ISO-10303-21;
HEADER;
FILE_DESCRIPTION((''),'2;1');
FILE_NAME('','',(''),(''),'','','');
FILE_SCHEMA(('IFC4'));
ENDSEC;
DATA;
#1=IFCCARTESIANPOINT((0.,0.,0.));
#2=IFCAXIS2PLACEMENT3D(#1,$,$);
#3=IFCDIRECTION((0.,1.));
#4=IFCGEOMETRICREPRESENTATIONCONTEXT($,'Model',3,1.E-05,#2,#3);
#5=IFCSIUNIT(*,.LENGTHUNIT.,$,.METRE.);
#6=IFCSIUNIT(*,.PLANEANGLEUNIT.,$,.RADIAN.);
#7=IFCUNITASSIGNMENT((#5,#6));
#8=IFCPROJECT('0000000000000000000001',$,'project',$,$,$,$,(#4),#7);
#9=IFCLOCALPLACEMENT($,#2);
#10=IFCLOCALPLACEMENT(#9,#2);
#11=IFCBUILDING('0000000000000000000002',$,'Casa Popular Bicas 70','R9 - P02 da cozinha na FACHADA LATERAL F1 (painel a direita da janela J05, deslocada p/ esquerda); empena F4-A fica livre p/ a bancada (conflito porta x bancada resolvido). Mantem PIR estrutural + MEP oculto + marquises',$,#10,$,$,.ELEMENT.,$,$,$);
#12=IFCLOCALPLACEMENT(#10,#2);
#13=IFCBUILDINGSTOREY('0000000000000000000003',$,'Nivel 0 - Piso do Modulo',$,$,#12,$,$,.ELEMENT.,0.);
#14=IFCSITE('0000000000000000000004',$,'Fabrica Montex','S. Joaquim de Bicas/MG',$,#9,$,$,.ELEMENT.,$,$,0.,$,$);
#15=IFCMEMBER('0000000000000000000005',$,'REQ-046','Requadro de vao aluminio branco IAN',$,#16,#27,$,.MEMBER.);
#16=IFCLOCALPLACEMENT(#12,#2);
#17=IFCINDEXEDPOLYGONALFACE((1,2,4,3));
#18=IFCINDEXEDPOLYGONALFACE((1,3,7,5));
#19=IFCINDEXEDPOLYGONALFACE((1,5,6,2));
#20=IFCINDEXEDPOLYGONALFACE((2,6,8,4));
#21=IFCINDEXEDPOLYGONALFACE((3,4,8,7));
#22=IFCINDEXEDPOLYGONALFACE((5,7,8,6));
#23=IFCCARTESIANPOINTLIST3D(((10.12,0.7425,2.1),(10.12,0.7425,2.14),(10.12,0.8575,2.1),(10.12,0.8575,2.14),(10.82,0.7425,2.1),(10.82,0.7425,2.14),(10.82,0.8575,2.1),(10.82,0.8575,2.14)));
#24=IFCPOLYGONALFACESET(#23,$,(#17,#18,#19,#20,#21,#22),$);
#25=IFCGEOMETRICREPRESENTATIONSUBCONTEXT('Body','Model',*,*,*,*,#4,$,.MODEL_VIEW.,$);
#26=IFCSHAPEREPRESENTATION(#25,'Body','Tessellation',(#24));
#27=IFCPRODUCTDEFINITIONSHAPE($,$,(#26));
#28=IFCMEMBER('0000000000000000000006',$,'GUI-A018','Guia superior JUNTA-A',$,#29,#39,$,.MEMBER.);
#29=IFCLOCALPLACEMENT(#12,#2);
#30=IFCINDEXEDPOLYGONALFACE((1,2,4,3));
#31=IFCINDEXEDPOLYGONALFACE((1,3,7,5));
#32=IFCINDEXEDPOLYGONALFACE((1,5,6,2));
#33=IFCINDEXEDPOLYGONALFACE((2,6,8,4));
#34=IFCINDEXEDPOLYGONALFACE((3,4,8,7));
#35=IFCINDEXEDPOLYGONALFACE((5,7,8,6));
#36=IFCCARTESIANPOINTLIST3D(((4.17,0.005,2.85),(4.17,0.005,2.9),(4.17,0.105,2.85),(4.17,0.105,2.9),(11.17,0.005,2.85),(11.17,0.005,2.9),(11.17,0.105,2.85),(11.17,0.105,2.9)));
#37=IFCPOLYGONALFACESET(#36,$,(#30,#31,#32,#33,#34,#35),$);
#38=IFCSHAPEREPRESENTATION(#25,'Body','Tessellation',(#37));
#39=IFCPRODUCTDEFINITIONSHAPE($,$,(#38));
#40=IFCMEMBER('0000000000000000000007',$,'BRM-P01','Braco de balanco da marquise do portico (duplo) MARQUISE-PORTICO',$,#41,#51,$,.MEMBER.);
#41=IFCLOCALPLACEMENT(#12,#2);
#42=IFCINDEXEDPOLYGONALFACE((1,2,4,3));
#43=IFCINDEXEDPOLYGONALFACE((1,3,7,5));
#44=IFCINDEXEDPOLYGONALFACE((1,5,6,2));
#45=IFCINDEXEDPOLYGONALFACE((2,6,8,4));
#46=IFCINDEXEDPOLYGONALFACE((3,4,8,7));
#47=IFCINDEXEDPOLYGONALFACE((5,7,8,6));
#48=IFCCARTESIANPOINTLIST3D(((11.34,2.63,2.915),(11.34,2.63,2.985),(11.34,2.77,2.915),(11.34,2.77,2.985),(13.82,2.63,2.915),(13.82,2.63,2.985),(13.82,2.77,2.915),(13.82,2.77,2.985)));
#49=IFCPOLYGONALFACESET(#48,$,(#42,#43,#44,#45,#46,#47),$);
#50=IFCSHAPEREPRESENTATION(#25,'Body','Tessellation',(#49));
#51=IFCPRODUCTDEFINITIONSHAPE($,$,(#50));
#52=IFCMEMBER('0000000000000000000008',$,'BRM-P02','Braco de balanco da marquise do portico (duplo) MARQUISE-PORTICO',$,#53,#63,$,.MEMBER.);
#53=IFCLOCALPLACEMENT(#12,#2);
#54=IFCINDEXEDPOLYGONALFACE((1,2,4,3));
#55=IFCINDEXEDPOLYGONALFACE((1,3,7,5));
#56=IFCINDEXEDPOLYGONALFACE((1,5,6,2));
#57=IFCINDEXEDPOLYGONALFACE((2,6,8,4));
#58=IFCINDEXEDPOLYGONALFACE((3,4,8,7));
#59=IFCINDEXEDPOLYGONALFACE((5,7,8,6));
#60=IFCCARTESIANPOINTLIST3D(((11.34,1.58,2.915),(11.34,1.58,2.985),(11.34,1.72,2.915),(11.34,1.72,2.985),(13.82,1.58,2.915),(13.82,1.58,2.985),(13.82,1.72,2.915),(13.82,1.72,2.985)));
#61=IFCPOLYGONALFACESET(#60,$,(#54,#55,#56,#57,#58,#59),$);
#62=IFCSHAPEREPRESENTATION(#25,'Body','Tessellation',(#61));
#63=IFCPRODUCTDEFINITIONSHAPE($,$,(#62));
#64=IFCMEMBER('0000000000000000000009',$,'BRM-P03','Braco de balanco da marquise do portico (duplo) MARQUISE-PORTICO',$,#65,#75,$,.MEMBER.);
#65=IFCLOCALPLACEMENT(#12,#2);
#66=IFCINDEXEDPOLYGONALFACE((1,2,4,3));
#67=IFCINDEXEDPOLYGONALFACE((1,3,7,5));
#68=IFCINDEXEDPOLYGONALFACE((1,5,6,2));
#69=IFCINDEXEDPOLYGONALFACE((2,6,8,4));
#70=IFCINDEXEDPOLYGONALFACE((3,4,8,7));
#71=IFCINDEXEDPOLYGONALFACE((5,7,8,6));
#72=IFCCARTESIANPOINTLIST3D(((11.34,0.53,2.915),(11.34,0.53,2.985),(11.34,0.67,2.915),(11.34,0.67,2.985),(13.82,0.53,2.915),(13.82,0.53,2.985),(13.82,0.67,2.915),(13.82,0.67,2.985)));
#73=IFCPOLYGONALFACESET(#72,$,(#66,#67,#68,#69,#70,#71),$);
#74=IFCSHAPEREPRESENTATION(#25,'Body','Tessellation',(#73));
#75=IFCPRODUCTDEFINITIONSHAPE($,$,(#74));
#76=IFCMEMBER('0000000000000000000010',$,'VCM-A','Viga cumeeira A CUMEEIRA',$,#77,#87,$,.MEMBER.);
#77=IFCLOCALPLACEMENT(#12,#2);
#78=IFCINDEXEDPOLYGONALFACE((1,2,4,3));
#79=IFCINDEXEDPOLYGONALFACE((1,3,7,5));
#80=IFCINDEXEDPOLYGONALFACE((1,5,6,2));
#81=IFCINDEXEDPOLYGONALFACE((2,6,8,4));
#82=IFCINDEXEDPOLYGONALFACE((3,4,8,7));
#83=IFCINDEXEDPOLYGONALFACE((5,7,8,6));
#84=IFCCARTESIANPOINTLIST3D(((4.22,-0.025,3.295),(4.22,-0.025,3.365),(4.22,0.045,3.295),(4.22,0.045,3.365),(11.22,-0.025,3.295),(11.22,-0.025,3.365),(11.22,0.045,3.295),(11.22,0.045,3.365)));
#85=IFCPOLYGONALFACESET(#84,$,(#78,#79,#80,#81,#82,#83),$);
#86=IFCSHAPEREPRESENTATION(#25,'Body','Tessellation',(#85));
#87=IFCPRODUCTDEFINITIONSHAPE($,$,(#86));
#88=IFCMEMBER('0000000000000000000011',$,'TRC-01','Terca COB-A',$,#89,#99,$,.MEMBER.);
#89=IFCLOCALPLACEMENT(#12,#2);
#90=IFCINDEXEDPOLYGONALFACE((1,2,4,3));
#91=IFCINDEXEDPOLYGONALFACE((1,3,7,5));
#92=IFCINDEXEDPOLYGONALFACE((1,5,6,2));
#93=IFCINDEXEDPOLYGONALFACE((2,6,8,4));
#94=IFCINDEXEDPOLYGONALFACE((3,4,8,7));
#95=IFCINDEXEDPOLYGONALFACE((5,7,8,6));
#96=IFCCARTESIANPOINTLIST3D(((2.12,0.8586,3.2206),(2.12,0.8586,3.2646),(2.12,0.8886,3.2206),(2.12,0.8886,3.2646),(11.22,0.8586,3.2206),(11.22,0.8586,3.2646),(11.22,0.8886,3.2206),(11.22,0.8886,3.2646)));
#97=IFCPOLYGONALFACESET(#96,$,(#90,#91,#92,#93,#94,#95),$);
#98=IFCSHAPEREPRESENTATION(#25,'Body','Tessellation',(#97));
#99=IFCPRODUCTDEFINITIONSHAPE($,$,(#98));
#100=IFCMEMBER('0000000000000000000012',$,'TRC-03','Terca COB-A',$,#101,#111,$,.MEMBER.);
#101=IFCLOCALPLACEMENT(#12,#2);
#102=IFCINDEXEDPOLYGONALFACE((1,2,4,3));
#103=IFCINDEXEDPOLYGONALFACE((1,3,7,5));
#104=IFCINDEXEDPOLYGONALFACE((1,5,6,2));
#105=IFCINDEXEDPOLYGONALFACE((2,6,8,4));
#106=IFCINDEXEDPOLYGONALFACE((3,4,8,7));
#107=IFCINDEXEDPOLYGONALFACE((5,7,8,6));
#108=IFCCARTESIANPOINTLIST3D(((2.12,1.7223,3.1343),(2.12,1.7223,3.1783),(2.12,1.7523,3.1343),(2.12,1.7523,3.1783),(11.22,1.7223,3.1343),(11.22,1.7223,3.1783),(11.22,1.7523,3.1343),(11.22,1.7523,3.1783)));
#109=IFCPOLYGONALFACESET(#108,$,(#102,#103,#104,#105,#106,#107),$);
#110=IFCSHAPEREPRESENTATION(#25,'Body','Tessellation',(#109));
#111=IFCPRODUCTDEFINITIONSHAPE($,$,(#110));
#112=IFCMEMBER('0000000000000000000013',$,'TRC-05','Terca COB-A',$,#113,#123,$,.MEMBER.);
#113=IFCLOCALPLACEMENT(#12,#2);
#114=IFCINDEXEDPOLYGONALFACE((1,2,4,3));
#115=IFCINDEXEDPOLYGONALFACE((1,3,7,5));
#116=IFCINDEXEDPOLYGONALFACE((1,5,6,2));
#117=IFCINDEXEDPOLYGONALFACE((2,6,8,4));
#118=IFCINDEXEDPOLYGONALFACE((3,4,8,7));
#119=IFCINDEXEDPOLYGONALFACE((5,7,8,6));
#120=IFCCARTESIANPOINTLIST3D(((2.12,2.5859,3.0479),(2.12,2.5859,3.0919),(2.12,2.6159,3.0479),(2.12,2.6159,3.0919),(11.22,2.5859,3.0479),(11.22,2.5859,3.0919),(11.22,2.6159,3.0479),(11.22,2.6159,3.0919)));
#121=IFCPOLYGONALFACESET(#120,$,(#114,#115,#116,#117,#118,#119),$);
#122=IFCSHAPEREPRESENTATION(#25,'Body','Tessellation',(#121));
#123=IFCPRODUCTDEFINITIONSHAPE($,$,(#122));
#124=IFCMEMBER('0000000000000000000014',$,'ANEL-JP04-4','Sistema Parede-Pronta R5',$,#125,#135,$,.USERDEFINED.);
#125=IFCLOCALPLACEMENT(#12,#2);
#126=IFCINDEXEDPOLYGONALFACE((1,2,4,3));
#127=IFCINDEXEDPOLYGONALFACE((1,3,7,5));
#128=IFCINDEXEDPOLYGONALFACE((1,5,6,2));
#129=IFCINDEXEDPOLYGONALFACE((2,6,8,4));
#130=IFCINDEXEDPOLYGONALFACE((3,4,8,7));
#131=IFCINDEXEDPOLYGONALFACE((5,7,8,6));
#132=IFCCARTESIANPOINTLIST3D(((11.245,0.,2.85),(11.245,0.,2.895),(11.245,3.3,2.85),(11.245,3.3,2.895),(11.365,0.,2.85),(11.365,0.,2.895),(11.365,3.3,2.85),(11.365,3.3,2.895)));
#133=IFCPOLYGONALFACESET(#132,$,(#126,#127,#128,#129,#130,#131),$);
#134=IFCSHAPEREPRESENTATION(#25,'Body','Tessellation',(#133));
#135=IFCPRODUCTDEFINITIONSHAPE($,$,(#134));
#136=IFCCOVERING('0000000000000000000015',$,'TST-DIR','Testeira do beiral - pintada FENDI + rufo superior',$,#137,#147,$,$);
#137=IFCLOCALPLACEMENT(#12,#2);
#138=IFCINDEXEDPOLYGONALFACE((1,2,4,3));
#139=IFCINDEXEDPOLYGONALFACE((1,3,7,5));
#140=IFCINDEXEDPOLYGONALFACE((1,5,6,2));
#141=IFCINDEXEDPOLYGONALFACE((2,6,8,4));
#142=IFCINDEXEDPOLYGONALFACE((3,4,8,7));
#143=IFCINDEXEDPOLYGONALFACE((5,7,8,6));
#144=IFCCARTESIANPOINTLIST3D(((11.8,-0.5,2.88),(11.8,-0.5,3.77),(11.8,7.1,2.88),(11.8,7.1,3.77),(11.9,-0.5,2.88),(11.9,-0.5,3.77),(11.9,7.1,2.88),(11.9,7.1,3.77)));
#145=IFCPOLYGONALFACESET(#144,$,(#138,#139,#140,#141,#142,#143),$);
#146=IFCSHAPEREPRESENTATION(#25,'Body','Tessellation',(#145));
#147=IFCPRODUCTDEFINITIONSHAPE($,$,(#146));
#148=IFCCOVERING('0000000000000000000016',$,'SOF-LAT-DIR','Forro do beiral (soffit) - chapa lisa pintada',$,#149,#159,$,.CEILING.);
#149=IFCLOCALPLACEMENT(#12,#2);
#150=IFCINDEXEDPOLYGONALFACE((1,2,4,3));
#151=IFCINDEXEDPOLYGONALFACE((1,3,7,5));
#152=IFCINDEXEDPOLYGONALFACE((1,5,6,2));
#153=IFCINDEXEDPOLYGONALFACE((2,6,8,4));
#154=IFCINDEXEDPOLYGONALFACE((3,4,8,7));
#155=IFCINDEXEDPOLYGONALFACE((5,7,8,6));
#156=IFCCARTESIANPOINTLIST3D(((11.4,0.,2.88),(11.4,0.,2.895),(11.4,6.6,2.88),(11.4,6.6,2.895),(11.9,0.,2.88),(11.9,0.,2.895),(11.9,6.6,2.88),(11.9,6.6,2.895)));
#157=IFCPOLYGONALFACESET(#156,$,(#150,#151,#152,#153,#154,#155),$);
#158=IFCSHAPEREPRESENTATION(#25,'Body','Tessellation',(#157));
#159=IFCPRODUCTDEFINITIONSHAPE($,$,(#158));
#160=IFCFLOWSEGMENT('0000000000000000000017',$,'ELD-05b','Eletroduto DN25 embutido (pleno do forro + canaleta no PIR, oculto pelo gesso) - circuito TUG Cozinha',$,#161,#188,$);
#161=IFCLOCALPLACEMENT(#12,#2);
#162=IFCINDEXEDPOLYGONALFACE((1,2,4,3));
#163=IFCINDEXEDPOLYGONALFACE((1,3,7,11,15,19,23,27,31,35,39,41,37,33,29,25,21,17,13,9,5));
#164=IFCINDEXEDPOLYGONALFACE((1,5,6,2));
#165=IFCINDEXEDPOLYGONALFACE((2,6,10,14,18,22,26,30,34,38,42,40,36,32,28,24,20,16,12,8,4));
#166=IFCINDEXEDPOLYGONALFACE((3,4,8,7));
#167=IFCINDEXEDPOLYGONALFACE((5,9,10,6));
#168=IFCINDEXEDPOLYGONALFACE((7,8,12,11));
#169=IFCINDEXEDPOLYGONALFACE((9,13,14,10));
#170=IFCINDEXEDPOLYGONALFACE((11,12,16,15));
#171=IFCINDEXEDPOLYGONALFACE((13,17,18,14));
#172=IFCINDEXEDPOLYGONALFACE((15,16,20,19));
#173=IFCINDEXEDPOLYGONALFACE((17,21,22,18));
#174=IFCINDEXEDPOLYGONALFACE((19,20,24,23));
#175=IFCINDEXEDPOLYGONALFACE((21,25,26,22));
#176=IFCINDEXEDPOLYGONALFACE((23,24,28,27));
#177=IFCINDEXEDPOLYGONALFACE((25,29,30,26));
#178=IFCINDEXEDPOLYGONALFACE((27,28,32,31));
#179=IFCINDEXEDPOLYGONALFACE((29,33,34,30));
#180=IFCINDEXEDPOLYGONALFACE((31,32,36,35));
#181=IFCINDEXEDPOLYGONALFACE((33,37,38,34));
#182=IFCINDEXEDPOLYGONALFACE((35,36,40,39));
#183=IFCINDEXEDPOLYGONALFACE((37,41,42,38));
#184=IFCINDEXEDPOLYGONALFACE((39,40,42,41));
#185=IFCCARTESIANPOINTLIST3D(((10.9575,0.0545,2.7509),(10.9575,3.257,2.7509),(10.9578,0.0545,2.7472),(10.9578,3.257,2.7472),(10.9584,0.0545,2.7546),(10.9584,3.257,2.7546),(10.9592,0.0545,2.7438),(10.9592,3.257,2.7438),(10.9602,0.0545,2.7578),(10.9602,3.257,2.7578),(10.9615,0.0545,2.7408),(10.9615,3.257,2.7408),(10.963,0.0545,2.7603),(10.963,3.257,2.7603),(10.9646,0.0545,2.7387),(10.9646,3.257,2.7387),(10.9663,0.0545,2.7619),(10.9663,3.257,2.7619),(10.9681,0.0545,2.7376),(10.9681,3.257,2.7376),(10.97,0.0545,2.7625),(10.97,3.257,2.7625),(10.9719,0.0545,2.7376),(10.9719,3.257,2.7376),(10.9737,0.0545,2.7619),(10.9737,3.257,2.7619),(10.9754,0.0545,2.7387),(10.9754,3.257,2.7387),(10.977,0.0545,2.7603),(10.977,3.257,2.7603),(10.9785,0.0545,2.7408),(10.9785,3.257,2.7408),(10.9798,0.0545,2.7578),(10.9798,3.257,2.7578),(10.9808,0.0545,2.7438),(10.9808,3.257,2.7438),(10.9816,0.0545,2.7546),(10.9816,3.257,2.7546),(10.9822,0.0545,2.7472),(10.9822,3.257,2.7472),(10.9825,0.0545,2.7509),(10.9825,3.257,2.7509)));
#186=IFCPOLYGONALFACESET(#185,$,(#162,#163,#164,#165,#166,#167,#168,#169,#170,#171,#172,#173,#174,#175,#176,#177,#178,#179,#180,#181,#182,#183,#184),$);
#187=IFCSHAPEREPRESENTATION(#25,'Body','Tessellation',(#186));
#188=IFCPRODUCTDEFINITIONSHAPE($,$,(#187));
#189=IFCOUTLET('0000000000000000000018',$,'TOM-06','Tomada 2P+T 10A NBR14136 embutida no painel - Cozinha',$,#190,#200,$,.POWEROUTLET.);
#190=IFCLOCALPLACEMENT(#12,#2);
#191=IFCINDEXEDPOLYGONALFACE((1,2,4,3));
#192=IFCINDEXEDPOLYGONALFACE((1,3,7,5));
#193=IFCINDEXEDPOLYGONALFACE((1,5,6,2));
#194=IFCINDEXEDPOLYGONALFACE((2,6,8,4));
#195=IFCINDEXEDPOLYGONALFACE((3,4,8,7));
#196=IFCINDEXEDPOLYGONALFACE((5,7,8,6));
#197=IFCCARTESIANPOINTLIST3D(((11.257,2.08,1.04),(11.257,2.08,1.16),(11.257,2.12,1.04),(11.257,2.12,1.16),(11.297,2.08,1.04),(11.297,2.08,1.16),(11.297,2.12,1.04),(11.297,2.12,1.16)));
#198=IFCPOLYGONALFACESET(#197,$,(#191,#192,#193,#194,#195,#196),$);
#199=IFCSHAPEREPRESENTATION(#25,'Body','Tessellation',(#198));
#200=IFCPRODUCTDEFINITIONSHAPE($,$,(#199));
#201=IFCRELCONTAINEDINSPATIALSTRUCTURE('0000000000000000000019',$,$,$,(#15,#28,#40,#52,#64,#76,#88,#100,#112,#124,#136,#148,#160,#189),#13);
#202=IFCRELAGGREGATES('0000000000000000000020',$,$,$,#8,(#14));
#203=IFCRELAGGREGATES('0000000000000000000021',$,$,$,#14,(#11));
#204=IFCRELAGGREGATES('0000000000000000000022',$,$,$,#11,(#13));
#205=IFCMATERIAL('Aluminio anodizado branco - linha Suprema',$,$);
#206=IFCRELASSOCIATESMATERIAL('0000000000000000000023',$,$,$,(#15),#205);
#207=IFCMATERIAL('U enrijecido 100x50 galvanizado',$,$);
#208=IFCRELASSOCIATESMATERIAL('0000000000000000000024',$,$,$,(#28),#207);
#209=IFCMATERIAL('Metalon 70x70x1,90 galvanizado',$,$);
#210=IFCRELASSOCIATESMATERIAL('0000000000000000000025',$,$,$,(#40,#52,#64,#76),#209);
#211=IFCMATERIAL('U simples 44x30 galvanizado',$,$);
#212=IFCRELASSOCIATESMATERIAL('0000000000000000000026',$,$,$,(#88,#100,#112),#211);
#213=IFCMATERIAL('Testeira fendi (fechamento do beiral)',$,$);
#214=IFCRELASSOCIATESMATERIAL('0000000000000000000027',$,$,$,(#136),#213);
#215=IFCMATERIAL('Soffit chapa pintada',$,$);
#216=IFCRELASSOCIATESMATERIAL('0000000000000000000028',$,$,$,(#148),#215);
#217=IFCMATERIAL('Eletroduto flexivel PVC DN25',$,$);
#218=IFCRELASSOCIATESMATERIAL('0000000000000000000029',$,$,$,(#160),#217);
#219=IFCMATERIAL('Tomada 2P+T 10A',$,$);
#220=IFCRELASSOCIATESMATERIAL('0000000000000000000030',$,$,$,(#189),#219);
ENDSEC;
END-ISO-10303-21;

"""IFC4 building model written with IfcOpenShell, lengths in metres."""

from ifc_helpers import new_model, si_unit, direction, frame, frame_2d, origin, origin_2d, place, context, subcontext, project, spatial, rectangle, circle, extrude, material, element, save


model = new_model("IFC4")

# Units and contexts
model_context = context("Model", 3, precision=1e-05, world=origin(), true_north=direction((0.0, 1.0)))
body_context = subcontext(model_context, "Body", "Model", "MODEL_VIEW")
ifc_project = project(units=[si_unit("LENGTHUNIT", "METRE"), si_unit("PLANEANGLEUNIT", "RADIAN")], contexts=[model_context])

# Site, building, storey
site_placement = place(None, origin())
site = spatial("IfcSite", under=ifc_project, at=site_placement, Name="Fabrica Montex", Description="S. Joaquim de Bicas/MG", CompositionType="ELEMENT", RefElevation=0.0)
building_placement = place(site_placement, origin())
building = spatial("IfcBuilding", under=site, at=building_placement, Name="Casa Popular Bicas 70", Description="R9 - P02 da cozinha na FACHADA LATERAL F1 (painel a direita da janela J05, deslocada p/ esquerda); empena F4-A fica livre p/ a bancada (conflito porta x bancada resolvido). Mantem PIR estrutural + MEP oculto + marquises", CompositionType="ELEMENT")
storey_placement = place(building_placement, origin())
storey = spatial("IfcBuildingStorey", under=building, at=storey_placement, Name="Nivel 0 - Piso do Modulo", CompositionType="ELEMENT", Elevation=0.0)

# Members
ifc_material_1 = material(Name="Aluminio anodizado branco - linha Suprema")
member_1_placement = place(None, frame((10.82, 0.8, 2.12), z_axis=(-1.0, 0.0, 0.0), x_axis=(0.0, 0.0, 1.0)))
element("IfcMember", 1, at=member_1_placement, inside=storey, material=ifc_material_1, Name="REQ-046", Description="Requadro de vao aluminio branco IAN", PredefinedType="MEMBER", context=body_context, shape_type="SweptSolid", body=[
    extrude(rectangle(XDim=0.04, YDim=0.115, at=origin_2d()), origin(), (0.0, 0.0, 1.0), 0.7),
])
ifc_material_2 = material(Name="U enrijecido 100x50 galvanizado")
member_2_placement = place(None, frame((11.17, 0.055, 2.875), z_axis=(-1.0, 0.0, 0.0), x_axis=(0.0, 0.0, 1.0)))
element("IfcMember", 2, at=member_2_placement, inside=storey, material=ifc_material_2, Name="GUI-A018", Description="Guia superior JUNTA-A", PredefinedType="MEMBER", context=body_context, shape_type="SweptSolid", body=[
    extrude(rectangle(XDim=0.05, YDim=0.1, at=origin_2d()), origin(), (0.0, 0.0, 1.0), 7.0),
])
ifc_material_3 = material(Name="Metalon 70x70x1,90 galvanizado")
for number, where, z_axis, x_axis, name in (
    (3, (11.34, 2.7, 2.95), (1.0, 0.0, 0.0), (0.0, 0.0, 1.0), "BRM-P01"),
    (4, (11.34, 1.65, 2.95), (1.0, 0.0, 0.0), (0.0, 0.0, 1.0), "BRM-P02"),
    (5, (11.34, 0.6, 2.95), (1.0, 0.0, 0.0), (0.0, 0.0, 1.0), "BRM-P03"),
):
    element("IfcMember", number, at=place(None, frame(where, z_axis=z_axis, x_axis=x_axis)), inside=storey, material=ifc_material_3, Name=name, Description="Braco de balanco da marquise do portico (duplo) MARQUISE-PORTICO", PredefinedType="MEMBER", context=body_context, shape_type="SweptSolid", body=[
        extrude(rectangle(XDim=0.07, YDim=0.14, at=origin_2d()), origin(), (0.0, 0.0, 1.0), 2.48),
    ])
member_3_placement = place(None, frame((11.22, 0.01, 3.33), z_axis=(-1.0, 0.0, 0.0), x_axis=(0.0, 0.0, 1.0)))
element("IfcMember", 6, at=member_3_placement, inside=storey, material=ifc_material_3, Name="VCM-A", Description="Viga cumeeira A CUMEEIRA", PredefinedType="MEMBER", context=body_context, shape_type="SweptSolid", body=[
    extrude(rectangle(XDim=0.07, YDim=0.07, at=origin_2d()), origin(), (0.0, 0.0, 1.0), 7.0),
])
ifc_material_4 = material(Name="U simples 44x30 galvanizado")
for number, where, z_axis, x_axis, name in (
    (7, (11.22, 0.8736, 3.2426), (-1.0, 0.0, 0.0), (0.0, 0.0, 1.0), "TRC-01"),
    (8, (11.22, 1.7373, 3.1563), (-1.0, 0.0, 0.0), (0.0, 0.0, 1.0), "TRC-03"),
    (9, (11.22, 2.6009, 3.0699), (-1.0, 0.0, 0.0), (0.0, 0.0, 1.0), "TRC-05"),
):
    element("IfcMember", number, at=place(None, frame(where, z_axis=z_axis, x_axis=x_axis)), inside=storey, material=ifc_material_4, Name=name, Description="Terca COB-A", PredefinedType="MEMBER", context=body_context, shape_type="SweptSolid", body=[
        extrude(rectangle(XDim=0.044, YDim=0.03, at=origin_2d()), origin(), (0.0, 0.0, 1.0), 9.1),
    ])
member_4_placement = place(storey_placement, frame((11.305, 1.65, 2.85)))
element("IfcMember", 10, at=member_4_placement, inside=storey, Name="ANEL-JP04-4", Description="Sistema Parede-Pronta R5", PredefinedType="USERDEFINED", context=body_context, shape_type="SweptSolid", body=[
    extrude(rectangle(XDim=0.12, YDim=3.3, at=origin_2d()), origin(), (0.0, 0.0, 1.0), 0.045),
])

# Coverings
ifc_material_5 = material(Name="Testeira fendi (fechamento do beiral)")
covering_1_placement = place(storey_placement, frame((11.85, -0.5, 2.88), x_axis=(0.0, 1.0, 0.0)))
element("IfcCovering", 11, at=covering_1_placement, inside=storey, material=ifc_material_5, Name="TST-DIR", Description="Testeira do beiral - pintada FENDI + rufo superior", context=body_context, shape_type="SweptSolid", body=[
    extrude(rectangle(XDim=7.6, YDim=0.1, at=frame_2d((3.8, 0.0))), origin(), (0.0, 0.0, 1.0), 0.89),
])
ifc_material_6 = material(Name="Soffit chapa pintada")
covering_2_placement = place(storey_placement, frame((11.4, 0.0, 2.88)))
element("IfcCovering", 12, at=covering_2_placement, inside=storey, material=ifc_material_6, Name="SOF-LAT-DIR", Description="Forro do beiral (soffit) - chapa lisa pintada", PredefinedType="CEILING", context=body_context, shape_type="SweptSolid", body=[
    extrude(rectangle(XDim=0.5, YDim=6.6, at=frame_2d((0.25, 3.3))), origin(), (0.0, 0.0, 1.0), 0.015),
])

# Flow segment
ifc_material_7 = material(Name="Eletroduto flexivel PVC DN25")
flow_segment_1_placement = place(None, frame((10.97, 0.0545, 2.75), z_axis=(0.0, 1.0, 0.0), x_axis=(0.0, 0.0, 1.0)))
element("IfcFlowSegment", 13, at=flow_segment_1_placement, inside=storey, material=ifc_material_7, Name="ELD-05b", Description="Eletroduto DN25 embutido (pleno do forro + canaleta no PIR, oculto pelo gesso) - circuito TUG Cozinha", context=body_context, shape_type="SweptSolid", body=[
    extrude(circle(Radius=0.0125, at=origin_2d()), origin(), (0.0, 0.0, 1.0), 3.2025),
])

# Outlet
ifc_material_8 = material(Name="Tomada 2P+T 10A")
outlet_1_placement = place(None, frame((11.297, 2.12, 1.04), z_axis=(0.0, 0.0, 1.0), x_axis=(-1.0, 0.0, 0.0)))
element("IfcOutlet", 14, at=outlet_1_placement, inside=storey, material=ifc_material_8, Name="TOM-06", Description="Tomada 2P+T 10A NBR14136 embutida no painel - Cozinha", PredefinedType="POWEROUTLET", context=body_context, shape_type="SweptSolid", body=[
    extrude(rectangle(XDim=0.04, YDim=0.04, at=frame_2d((0.02, 0.02))), origin(), (0.0, 0.0, 1.0), 0.12),
])

save(model, "model.ifc")
